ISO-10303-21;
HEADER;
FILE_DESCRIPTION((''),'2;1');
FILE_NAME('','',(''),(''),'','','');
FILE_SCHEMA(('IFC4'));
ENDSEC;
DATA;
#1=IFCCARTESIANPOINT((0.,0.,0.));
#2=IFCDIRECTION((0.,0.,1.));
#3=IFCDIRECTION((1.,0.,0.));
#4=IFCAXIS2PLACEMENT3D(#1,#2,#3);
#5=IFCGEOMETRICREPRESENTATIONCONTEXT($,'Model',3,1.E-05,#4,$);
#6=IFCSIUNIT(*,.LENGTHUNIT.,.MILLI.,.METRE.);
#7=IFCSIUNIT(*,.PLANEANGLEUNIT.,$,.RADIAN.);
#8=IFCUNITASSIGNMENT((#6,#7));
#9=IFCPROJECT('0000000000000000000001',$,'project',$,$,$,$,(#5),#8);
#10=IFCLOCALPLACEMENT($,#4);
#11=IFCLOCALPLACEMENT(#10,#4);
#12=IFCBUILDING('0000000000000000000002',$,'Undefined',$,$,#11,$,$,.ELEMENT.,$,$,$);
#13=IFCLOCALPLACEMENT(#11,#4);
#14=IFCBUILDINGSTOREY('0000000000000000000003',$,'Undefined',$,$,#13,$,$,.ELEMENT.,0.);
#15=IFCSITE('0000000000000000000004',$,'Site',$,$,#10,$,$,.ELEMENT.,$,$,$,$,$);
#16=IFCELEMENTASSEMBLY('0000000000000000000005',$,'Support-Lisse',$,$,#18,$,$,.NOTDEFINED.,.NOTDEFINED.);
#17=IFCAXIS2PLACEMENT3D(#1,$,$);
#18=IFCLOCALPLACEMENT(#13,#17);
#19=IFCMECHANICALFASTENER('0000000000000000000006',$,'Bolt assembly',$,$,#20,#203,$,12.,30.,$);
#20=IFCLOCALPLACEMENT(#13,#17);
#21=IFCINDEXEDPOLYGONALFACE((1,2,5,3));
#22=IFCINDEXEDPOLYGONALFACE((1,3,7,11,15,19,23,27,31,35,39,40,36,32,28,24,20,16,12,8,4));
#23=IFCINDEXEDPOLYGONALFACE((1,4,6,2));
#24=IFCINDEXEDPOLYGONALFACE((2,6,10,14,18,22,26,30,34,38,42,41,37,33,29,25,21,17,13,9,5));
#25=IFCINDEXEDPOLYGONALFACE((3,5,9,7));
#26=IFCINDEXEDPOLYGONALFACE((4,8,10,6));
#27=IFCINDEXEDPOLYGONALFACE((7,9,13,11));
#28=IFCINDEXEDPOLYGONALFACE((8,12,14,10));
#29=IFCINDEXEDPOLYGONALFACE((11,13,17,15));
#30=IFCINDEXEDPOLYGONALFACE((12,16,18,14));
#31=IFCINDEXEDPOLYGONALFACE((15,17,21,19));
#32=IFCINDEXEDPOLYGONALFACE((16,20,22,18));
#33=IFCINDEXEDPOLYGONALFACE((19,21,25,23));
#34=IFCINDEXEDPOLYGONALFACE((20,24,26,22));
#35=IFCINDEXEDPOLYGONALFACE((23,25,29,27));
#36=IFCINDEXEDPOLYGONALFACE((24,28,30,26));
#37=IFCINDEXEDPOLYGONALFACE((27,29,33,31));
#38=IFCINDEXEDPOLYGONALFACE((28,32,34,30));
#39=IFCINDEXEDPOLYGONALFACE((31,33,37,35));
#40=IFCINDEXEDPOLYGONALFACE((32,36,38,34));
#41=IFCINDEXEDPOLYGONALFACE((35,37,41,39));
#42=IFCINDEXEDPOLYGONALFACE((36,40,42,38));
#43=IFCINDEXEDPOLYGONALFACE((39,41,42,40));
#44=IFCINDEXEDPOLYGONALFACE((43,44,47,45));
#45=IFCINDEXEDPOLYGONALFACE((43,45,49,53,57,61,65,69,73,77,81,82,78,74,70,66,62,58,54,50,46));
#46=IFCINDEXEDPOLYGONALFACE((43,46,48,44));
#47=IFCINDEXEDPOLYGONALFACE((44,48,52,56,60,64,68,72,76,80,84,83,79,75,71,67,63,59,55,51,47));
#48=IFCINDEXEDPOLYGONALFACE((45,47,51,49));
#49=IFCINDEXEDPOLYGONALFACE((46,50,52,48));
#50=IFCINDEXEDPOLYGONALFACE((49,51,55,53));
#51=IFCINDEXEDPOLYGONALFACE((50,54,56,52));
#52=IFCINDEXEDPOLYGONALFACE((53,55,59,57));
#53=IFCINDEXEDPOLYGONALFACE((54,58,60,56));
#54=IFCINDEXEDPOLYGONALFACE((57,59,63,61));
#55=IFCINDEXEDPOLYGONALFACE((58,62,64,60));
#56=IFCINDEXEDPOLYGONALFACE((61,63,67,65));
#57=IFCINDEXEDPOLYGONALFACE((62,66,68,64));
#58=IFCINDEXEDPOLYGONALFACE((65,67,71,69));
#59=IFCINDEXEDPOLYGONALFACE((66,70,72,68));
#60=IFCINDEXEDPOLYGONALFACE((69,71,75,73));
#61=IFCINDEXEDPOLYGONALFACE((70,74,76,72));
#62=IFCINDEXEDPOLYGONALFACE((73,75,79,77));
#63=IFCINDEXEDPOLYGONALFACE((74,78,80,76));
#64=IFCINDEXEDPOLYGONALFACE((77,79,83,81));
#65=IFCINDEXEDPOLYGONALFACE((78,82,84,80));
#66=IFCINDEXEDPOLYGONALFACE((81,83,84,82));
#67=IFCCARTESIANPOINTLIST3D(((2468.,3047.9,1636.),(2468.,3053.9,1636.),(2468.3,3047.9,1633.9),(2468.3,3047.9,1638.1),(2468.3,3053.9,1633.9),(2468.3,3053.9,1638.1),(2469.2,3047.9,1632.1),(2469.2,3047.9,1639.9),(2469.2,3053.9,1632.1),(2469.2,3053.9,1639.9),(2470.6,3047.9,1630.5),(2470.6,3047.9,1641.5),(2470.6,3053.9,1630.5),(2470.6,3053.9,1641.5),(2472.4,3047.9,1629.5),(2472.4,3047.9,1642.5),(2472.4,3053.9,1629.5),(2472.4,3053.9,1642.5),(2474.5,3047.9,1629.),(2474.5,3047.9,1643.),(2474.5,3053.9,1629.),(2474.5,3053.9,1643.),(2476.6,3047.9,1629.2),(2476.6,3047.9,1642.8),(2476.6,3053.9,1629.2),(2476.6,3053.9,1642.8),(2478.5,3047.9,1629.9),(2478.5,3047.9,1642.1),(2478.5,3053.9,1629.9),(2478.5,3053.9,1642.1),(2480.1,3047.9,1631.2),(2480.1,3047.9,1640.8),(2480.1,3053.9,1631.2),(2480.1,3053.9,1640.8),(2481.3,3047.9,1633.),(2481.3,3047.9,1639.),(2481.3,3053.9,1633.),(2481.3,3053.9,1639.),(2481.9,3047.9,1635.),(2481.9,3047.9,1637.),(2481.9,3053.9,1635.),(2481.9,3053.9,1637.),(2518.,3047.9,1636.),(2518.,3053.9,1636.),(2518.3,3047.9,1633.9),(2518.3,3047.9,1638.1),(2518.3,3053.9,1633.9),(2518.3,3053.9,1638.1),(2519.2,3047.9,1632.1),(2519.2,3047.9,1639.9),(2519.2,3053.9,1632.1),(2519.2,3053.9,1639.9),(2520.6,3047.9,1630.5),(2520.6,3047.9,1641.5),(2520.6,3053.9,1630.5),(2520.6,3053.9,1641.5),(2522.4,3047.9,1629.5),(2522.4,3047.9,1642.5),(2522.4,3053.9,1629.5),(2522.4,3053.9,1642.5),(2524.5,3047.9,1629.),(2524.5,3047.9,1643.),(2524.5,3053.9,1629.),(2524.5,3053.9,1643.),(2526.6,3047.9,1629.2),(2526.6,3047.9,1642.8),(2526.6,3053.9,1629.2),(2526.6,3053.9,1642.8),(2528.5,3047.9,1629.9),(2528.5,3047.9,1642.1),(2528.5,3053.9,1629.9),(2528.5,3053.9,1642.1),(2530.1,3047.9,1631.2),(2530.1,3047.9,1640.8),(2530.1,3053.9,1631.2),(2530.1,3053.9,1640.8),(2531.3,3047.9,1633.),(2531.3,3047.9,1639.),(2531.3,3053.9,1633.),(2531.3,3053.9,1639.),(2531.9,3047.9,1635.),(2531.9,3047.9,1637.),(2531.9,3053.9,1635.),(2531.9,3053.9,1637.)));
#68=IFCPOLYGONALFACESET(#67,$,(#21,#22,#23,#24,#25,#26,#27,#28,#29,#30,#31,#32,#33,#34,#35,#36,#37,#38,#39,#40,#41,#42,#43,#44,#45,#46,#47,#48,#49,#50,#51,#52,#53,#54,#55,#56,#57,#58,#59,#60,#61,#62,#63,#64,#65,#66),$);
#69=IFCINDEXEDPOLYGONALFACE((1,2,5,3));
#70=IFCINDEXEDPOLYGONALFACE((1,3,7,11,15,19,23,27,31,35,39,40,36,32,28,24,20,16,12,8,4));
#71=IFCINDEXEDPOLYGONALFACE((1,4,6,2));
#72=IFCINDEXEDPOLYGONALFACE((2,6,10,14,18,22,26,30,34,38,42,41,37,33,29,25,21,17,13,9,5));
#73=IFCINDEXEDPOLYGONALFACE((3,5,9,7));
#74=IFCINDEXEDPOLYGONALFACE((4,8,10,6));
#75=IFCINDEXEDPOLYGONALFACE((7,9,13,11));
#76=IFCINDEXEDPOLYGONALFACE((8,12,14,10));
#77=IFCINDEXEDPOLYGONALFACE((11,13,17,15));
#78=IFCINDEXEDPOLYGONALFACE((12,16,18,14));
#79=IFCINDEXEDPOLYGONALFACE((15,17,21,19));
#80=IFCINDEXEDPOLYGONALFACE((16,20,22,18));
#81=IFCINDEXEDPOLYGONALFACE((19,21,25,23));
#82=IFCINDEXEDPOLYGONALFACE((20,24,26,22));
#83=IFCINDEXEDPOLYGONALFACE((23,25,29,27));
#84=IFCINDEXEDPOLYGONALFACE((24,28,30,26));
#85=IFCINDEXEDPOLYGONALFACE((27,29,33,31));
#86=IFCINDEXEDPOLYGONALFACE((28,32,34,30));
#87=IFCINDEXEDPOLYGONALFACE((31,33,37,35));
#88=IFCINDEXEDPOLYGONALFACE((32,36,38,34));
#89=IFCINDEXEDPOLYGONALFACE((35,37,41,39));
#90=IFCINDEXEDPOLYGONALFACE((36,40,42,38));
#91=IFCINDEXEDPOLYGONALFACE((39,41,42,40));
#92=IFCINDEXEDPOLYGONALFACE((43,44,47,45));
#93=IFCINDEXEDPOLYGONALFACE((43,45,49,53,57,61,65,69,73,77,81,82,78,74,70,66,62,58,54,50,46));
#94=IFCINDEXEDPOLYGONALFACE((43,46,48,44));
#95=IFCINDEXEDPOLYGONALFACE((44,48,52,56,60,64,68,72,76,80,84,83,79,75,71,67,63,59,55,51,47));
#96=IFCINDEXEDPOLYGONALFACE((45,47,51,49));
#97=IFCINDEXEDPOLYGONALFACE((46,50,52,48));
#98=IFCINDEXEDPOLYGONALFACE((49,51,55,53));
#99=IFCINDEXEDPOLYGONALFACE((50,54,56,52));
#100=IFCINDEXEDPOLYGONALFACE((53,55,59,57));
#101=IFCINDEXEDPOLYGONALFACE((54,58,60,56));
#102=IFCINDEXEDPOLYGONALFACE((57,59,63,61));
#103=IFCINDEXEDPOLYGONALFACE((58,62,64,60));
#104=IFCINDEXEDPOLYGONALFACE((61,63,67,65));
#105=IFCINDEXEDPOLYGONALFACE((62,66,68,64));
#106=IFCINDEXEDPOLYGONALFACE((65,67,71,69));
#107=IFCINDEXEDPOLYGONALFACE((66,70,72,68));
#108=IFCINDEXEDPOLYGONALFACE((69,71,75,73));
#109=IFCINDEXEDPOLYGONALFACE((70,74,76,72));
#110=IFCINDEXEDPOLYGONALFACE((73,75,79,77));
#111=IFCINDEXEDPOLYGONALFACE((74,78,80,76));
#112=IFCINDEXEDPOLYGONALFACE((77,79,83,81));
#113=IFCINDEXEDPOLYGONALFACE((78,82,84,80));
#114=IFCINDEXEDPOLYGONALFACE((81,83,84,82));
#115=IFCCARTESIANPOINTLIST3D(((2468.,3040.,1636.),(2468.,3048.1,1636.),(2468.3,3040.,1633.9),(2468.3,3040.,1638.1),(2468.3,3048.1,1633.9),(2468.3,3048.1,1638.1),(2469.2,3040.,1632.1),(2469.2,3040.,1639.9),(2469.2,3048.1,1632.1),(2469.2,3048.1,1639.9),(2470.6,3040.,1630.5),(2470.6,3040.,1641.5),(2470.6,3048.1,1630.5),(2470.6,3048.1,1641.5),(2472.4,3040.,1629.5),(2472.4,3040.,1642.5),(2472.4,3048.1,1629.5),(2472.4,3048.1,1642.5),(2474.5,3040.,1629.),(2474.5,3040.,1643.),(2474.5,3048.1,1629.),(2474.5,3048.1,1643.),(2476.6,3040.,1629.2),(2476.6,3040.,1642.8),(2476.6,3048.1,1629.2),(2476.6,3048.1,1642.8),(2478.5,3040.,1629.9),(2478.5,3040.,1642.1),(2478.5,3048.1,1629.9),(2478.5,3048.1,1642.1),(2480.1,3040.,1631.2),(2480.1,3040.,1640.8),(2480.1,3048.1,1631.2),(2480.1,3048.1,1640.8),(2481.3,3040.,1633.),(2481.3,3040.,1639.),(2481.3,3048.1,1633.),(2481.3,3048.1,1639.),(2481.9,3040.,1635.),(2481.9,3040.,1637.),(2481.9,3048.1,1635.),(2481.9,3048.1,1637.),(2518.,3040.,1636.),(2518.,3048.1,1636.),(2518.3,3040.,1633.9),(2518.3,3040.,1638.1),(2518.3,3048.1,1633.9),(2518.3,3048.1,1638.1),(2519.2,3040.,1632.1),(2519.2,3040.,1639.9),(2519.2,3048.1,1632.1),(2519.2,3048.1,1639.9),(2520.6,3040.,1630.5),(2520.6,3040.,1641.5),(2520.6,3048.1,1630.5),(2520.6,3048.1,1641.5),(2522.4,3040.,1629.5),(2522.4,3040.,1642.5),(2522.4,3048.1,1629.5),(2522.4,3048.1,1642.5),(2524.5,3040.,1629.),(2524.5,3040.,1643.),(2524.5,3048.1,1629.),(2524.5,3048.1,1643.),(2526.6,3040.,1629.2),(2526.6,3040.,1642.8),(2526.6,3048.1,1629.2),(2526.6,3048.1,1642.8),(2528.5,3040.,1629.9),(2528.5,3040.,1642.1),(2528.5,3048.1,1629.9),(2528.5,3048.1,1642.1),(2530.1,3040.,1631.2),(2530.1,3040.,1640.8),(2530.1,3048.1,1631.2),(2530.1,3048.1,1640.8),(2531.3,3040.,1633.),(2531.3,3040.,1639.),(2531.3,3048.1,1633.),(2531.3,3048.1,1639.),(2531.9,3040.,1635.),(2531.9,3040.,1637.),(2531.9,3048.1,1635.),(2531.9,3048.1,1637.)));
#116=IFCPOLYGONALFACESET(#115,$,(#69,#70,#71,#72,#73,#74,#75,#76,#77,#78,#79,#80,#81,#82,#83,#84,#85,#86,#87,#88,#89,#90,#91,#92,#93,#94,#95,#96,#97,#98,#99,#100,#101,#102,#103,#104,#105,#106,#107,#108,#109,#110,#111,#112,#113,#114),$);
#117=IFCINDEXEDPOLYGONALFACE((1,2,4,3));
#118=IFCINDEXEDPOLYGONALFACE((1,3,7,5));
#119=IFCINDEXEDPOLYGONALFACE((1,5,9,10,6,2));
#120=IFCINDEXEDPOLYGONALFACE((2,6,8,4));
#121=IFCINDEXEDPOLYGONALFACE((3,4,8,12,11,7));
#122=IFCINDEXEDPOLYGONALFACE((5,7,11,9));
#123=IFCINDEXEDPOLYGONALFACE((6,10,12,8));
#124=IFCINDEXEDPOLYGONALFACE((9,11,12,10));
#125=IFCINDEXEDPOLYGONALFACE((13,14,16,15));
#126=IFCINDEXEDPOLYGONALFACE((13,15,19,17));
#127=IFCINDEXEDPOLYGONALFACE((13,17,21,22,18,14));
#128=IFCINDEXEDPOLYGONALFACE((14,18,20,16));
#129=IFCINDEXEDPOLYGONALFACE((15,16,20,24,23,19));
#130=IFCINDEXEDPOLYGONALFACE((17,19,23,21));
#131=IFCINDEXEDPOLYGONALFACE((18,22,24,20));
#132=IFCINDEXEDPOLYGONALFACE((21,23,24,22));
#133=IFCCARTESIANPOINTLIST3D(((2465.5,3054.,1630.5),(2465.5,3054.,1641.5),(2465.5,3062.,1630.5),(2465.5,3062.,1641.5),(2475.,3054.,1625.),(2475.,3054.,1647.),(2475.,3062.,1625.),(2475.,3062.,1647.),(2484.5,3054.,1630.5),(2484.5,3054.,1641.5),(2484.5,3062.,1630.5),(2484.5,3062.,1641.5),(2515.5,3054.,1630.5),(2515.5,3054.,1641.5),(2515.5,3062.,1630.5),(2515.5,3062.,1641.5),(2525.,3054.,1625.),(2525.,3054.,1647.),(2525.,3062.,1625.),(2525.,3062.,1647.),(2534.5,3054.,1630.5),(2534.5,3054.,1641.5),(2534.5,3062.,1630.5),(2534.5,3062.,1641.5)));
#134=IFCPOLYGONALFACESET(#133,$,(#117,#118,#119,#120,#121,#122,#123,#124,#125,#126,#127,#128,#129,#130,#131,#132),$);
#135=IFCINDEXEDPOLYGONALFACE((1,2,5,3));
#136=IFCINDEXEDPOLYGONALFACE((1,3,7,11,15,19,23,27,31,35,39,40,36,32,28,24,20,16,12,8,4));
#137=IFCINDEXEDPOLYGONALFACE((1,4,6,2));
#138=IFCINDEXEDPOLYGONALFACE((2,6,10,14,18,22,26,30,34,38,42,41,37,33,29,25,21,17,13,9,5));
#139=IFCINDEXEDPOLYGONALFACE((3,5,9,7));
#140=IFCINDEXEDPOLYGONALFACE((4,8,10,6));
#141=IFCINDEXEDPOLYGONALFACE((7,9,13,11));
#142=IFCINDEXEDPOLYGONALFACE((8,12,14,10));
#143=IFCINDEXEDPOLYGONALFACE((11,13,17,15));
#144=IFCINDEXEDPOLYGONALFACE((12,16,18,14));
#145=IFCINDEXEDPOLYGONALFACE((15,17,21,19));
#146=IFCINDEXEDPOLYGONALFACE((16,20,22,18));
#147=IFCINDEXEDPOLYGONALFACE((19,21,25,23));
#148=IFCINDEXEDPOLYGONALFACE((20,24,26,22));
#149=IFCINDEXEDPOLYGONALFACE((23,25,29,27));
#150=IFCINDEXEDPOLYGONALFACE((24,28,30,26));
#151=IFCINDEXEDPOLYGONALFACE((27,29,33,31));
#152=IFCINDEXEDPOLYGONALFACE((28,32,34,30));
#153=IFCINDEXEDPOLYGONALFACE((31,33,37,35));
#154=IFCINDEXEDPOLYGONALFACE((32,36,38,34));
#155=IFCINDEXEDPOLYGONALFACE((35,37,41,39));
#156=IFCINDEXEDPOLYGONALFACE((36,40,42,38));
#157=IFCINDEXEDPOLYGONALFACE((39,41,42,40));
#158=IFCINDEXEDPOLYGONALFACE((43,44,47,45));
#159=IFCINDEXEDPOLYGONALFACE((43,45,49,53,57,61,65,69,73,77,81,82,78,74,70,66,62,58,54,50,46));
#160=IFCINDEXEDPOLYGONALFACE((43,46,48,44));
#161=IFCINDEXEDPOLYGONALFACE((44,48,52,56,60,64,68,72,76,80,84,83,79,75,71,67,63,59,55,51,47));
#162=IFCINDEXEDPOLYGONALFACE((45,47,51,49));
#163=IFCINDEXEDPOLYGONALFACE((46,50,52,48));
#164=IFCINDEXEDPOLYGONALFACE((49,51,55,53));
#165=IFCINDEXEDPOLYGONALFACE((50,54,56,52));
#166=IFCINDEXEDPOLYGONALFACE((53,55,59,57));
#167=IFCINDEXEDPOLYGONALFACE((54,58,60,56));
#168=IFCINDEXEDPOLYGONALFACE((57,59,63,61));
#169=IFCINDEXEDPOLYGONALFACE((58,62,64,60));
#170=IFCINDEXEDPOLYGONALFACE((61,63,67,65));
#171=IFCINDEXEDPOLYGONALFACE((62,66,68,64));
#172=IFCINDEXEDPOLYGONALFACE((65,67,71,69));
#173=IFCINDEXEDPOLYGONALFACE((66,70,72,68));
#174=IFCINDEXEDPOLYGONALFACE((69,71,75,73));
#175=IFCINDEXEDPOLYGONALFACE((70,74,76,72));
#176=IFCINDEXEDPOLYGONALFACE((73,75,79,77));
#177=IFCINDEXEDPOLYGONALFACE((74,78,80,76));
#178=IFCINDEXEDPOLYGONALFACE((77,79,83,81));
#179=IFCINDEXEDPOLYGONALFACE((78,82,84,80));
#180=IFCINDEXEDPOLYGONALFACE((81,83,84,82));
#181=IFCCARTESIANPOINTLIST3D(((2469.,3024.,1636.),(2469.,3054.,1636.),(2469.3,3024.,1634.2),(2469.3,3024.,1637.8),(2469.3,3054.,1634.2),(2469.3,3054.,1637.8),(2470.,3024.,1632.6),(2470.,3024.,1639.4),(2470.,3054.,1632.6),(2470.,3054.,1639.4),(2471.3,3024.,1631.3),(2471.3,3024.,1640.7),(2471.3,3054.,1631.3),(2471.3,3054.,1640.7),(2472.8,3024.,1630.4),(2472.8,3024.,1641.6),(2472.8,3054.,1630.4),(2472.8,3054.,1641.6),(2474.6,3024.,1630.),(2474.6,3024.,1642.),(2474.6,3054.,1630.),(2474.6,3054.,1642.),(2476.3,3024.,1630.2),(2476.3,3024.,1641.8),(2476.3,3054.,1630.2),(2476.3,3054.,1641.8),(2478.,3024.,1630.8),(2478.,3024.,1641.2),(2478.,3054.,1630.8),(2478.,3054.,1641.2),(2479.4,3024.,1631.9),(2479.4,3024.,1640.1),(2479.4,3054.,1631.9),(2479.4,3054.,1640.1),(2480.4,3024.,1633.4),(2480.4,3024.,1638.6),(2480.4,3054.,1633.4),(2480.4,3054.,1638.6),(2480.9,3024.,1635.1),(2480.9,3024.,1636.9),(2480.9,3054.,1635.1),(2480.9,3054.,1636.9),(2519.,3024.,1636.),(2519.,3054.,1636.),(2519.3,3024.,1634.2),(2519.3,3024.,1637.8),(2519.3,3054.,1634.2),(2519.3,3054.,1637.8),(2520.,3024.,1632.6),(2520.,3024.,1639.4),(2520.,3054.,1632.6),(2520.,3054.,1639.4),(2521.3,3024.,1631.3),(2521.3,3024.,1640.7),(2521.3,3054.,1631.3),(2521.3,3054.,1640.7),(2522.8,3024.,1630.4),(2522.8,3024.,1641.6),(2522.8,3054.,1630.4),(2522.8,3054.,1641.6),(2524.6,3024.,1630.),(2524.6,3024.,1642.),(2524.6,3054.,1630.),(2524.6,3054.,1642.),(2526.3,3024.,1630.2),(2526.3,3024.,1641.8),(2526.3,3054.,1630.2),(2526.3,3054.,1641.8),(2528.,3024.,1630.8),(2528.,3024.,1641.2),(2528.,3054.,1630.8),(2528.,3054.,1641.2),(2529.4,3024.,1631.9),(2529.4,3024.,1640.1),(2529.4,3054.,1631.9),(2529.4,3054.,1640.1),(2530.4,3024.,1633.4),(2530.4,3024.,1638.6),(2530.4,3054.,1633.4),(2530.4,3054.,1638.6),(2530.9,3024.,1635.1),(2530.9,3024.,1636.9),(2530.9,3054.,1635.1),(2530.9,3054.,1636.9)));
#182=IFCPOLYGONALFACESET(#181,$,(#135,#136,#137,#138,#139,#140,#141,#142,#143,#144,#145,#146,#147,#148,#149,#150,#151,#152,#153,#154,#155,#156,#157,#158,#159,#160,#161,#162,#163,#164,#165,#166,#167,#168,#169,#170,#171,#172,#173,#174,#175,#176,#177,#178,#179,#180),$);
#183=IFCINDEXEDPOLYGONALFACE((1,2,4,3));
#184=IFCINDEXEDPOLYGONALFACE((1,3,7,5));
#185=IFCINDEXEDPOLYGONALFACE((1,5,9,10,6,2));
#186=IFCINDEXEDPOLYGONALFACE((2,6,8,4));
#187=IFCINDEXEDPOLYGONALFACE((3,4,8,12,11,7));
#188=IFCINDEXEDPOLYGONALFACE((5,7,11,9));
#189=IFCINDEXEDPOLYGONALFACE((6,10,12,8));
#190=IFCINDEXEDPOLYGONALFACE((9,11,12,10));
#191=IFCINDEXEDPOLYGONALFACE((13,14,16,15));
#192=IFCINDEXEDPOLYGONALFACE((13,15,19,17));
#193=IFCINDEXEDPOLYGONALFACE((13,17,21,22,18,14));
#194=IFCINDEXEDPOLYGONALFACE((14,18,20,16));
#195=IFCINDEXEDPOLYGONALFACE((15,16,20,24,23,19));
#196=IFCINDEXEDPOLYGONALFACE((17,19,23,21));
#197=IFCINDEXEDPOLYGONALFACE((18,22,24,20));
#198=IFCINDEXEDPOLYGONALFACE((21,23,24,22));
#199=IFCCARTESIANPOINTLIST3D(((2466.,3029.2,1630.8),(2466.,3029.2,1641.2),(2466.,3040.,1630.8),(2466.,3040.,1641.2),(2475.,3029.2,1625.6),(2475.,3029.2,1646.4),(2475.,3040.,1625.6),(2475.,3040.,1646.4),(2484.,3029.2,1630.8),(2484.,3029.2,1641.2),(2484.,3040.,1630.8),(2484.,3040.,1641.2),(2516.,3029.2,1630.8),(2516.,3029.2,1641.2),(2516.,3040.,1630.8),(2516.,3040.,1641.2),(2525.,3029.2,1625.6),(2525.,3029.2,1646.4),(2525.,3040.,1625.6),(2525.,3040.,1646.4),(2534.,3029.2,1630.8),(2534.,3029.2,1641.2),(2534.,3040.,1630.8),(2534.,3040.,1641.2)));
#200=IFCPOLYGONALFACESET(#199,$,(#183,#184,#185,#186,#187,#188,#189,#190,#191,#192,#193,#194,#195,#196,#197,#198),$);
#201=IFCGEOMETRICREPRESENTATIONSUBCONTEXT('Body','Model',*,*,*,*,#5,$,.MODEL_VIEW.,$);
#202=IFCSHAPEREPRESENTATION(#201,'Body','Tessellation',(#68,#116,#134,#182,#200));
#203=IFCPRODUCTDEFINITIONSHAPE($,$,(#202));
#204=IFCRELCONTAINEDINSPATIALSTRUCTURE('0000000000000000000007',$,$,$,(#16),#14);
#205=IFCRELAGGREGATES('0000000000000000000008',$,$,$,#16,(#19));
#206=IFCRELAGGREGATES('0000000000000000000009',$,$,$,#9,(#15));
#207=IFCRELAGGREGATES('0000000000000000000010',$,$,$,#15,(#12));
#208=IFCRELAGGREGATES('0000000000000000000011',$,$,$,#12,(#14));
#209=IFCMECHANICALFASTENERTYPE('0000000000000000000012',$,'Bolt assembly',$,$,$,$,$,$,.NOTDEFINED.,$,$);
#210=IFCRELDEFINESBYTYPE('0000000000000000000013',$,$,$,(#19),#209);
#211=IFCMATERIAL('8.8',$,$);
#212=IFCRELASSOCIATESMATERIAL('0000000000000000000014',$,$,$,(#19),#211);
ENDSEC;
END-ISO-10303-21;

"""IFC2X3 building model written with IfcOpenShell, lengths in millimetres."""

from ifc_helpers import new_model, si_unit, frame, origin_with_axes, origin_2d_with_axis, place, context, subcontext, project, spatial, polyline, circle, outline, extrude, source, transform, mapped, material, type_object, element, aggregate, save


model = new_model("IFC2X3")

# Units and contexts
model_context = context("Model", 3, precision=1e-05, world=origin_with_axes())
body_context = subcontext(model_context, "Body", "Model", "MODEL_VIEW")
ifc_project = project(units=[si_unit("LENGTHUNIT", "METRE", prefix="MILLI"), si_unit("PLANEANGLEUNIT", "RADIAN")], contexts=[model_context])

# Site, building, storey
site_placement = place(None, origin_with_axes())
site = spatial("IfcSite", under=ifc_project, at=site_placement, Name="Site", CompositionType="ELEMENT")
building_placement = place(site_placement, origin_with_axes())
building = spatial("IfcBuilding", under=site, at=building_placement, Name="Undefined", CompositionType="ELEMENT")
storey_placement = place(building_placement, origin_with_axes())
storey = spatial("IfcBuildingStorey", under=building, at=storey_placement, Name="Undefined", CompositionType="ELEMENT", Elevation=0.0)

# Shared definitions
mechanical_fastener_type = type_object("IfcMechanicalFastenerType", Name="Bolt assembly")
ifc_material_1 = material(Name="8.8")

# Element assembly, mechanical fastener
shared_shape_1 = source(origin_with_axes(), body_context, "Body", "SweptSolid", [
    extrude(circle(Radius=7.0, at=origin_2d_with_axis()), frame((0.0, -5.9, 0.0), z_axis=(0.0, 1.0, 0.0), x_axis=(1.0, 0.0, 0.0)), (0.0, 0.0, 1.0), 6.0),
    extrude(circle(Radius=7.0, at=origin_2d_with_axis()), frame((0.0, -0.1, 0.0), z_axis=(0.0, 1.0, 0.0), x_axis=(1.0, 0.0, 0.0)), (0.0, 0.0, 1.0), 8.1),
    extrude(outline(polyline([(9.5, -5.5), (9.5, 5.5), (0.0, 11.0), (-9.5, 5.5), (-9.5, -5.5), (0.0, -11.0), (9.5, -5.5)])), frame((0.0, -14.0, 0.0), z_axis=(0.0, 1.0, 0.0), x_axis=(1.0, 0.0, 0.0)), (0.0, 0.0, 1.0), 8.0),
    extrude(circle(Radius=6.0, at=origin_2d_with_axis()), frame((0.0, -6.0, 0.0), z_axis=(0.0, 1.0, 0.0), x_axis=(1.0, 0.0, 0.0)), (0.0, 0.0, 1.0), 30.0),
    extrude(outline(polyline([(9.0, -5.2), (9.0, 5.2), (0.0, 10.4), (-9.0, 5.2), (-9.0, -5.2), (0.0, -10.4), (9.0, -5.2)])), frame((0.0, 8.0, 0.0), z_axis=(0.0, 1.0, 0.0), x_axis=(1.0, 0.0, 0.0)), (0.0, 0.0, 1.0), 10.8),
])
assembly_1_placement = place(storey_placement, origin_with_axes())
assembly_1 = element("IfcElementAssembly", 1, at=assembly_1_placement, inside=storey, Name="Support-Lisse", AssemblyPlace="NOTDEFINED", PredefinedType="NOTDEFINED")
mechanical_fastener_1_placement = place(assembly_1_placement, frame((2525.0, 3048.0, 1636.0), z_axis=(0.0, 0.0, 1.0), x_axis=(-1.0, 0.0, 0.0)))
mechanical_fastener_1 = element("IfcMechanicalFastener", 2, at=mechanical_fastener_1_placement, type_object=mechanical_fastener_type, material=ifc_material_1, Name="Bolt assembly", NominalDiameter=12.0, NominalLength=30.0, context=body_context, shape_type="MappedRepresentation", body=[
    mapped(shared_shape_1, transform((0.0, 0.0, 0.0))),
    mapped(shared_shape_1, transform((50.0, 0.0, 0.0))),
])
aggregate(assembly_1, [mechanical_fastener_1])

save(model, "model.ifc")
